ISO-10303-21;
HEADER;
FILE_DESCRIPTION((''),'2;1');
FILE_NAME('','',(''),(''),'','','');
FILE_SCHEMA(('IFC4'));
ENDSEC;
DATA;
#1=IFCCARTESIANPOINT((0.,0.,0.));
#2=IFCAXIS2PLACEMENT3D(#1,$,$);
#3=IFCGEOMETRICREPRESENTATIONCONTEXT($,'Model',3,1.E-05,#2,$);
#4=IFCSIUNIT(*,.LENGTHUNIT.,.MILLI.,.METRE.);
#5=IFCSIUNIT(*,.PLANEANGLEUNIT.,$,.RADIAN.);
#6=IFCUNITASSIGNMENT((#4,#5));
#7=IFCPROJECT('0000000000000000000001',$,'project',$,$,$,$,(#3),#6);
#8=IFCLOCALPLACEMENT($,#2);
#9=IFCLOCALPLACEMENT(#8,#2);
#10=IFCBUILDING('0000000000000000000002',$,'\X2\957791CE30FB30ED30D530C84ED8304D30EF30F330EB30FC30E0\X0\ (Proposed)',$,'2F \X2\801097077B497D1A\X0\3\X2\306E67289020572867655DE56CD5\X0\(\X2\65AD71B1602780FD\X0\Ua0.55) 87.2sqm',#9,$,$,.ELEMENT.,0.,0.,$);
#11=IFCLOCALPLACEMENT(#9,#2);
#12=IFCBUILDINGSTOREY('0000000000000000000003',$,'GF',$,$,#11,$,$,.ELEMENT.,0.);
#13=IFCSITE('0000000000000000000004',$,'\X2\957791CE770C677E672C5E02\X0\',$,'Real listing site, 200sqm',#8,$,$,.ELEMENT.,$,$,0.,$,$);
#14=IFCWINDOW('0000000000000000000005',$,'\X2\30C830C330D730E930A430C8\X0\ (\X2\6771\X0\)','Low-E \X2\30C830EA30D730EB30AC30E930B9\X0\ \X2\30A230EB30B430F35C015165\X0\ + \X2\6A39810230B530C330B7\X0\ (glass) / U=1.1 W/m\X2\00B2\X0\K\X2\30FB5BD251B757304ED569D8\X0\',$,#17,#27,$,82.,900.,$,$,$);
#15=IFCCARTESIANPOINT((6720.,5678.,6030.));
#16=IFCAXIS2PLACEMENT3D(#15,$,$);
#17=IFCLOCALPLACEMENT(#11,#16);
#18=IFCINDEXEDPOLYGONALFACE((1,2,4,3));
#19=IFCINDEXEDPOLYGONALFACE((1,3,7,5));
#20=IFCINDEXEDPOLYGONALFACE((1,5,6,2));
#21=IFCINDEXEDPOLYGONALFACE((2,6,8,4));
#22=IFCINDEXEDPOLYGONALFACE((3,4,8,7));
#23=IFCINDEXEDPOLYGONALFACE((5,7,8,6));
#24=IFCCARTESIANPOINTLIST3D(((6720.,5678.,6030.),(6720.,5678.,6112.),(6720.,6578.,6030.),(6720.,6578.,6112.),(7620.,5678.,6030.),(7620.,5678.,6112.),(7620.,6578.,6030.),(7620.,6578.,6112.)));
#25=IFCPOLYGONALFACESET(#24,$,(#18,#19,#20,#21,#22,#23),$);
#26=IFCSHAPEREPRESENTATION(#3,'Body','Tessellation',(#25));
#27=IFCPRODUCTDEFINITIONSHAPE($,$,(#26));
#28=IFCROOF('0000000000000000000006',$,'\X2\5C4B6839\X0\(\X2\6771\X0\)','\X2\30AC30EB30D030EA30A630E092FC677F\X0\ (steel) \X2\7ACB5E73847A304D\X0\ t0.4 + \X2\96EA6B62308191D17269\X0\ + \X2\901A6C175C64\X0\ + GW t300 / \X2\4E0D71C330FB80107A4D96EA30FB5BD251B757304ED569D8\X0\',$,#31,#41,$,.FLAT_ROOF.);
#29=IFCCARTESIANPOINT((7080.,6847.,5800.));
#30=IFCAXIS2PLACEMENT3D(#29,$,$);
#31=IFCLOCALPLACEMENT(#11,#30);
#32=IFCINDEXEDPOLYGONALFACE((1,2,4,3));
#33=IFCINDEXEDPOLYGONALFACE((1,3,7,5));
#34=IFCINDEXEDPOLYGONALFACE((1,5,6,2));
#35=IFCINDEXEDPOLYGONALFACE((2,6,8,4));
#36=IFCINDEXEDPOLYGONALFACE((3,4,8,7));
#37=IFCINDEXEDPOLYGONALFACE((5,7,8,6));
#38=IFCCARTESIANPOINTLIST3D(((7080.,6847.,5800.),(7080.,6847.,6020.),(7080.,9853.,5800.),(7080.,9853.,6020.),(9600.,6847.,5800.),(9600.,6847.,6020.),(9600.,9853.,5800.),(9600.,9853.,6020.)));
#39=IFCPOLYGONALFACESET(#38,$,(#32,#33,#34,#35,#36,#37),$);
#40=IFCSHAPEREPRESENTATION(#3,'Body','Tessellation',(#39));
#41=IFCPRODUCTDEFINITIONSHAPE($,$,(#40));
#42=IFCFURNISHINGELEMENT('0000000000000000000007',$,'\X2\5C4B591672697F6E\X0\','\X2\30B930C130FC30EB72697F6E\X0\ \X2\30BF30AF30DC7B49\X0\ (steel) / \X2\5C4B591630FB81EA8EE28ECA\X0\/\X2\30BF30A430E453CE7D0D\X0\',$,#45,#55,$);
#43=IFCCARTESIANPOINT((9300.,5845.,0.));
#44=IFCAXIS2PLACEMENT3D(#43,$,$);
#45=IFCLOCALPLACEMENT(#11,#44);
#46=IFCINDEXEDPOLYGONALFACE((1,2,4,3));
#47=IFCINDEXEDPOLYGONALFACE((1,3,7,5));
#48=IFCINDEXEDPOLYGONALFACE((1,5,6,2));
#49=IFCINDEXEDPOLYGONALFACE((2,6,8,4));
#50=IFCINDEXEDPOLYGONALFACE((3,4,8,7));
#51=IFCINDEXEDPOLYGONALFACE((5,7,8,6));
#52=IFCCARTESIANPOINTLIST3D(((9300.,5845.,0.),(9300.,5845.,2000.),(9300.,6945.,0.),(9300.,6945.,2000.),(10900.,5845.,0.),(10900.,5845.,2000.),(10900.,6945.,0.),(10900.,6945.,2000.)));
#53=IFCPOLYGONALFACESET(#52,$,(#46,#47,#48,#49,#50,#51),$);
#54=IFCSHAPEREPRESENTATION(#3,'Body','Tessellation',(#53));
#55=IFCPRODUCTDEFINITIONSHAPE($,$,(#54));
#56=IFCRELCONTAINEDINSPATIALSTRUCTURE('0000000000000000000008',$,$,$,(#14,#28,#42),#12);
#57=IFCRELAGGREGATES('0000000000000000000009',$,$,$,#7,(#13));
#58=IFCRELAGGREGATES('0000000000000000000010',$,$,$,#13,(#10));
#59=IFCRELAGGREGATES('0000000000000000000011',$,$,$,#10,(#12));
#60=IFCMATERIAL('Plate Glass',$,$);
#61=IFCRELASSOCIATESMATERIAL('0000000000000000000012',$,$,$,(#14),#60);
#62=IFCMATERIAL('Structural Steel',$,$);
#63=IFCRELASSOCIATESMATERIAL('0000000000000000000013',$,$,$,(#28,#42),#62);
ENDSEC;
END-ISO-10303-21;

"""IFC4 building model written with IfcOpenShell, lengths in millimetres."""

from ifc_helpers import new_model, si_unit, frame, frame_2d, origin, place, context, project, spatial, rectangle, extrude, material, element, save


model = new_model("IFC4")

# Units and contexts
model_context = context("Model", 3, precision=1e-05, world=origin())
ifc_project = project(units=[si_unit("LENGTHUNIT", "METRE", prefix="MILLI"), si_unit("PLANEANGLEUNIT", "RADIAN")], contexts=[model_context])

# Site, building, storey
site_placement = place(None, origin())
site = spatial("IfcSite", under=ifc_project, at=site_placement, Name="長野県松本市", ObjectType="Real listing site, 200sqm", CompositionType="ELEMENT", RefElevation=0.0)
building_placement = place(site_placement, origin())
building = spatial("IfcBuilding", under=site, at=building_placement, Name="長野・ロフト付きワンルーム (Proposed)", ObjectType="2F 耐震等級3の木造在来工法(断熱性能Ua0.55) 87.2sqm", CompositionType="ELEMENT", ElevationOfRefHeight=0.0, ElevationOfTerrain=0.0)
storey_placement = place(building_placement, origin())
storey = spatial("IfcBuildingStorey", under=building, at=storey_placement, Name="GF", CompositionType="ELEMENT", Elevation=0.0)

# Shared definitions
ifc_material_1 = material(Name="Plate Glass")

# Window
window_1_placement = place(storey_placement, frame((6720.0, 5678.0, 6030.0)))
element("IfcWindow", 1, at=window_1_placement, inside=storey, material=ifc_material_1, Name="トップライト (東)", Description="Low-E トリプルガラス アルゴン封入 + 樹脂サッシ (glass) / U=1.1 W/m²K・寒冷地仕様", OverallHeight=82.0, OverallWidth=900.0, context=model_context, shape_type="SweptSolid", body=[
    extrude(rectangle(XDim=900.0, YDim=900.0, at=frame_2d((450.0, 450.0))), frame((6720.0, 5678.0, 6030.0)), (0.0, 0.0, 1.0), 82.0),
])

# Roof
ifc_material_2 = material(Name="Structural Steel")
for number, where, name in (
    (2, (7080.0, 6847.0, 5800.0), "屋根(東)"),
):
    element("IfcRoof", number, at=place(storey_placement, frame(where)), inside=storey, material=ifc_material_2, Name=name, Description="ガルバリウム鋼板 (steel) 立平葺き t0.4 + 雪止め金物 + 通気層 + GW t300 / 不燃・耐積雪・寒冷地仕様", PredefinedType="FLAT_ROOF", context=model_context, shape_type="SweptSolid", body=[
        extrude(rectangle(XDim=2520.0, YDim=3006.0, at=frame_2d((1260.0, 1503.0))), frame((7080.0, 6847.0, 5800.0)), (0.0, 0.0, 1.0), 220.0),
    ])

# Furnishing element
furnishing_placement = place(storey_placement, frame((9300.0, 5845.0, 0.0)))
element("IfcFurnishingElement", 3, at=furnishing_placement, inside=storey, material=ifc_material_2, Name="屋外物置", Description="スチール物置 タクボ等 (steel) / 屋外・自転車/タイヤ収納", context=model_context, shape_type="SweptSolid", body=[
    extrude(rectangle(XDim=1600.0, YDim=1100.0, at=frame_2d((800.0, 550.0))), frame((9300.0, 5845.0, 0.0)), (0.0, 0.0, 1.0), 2000.0),
])

save(model, "model.ifc")
